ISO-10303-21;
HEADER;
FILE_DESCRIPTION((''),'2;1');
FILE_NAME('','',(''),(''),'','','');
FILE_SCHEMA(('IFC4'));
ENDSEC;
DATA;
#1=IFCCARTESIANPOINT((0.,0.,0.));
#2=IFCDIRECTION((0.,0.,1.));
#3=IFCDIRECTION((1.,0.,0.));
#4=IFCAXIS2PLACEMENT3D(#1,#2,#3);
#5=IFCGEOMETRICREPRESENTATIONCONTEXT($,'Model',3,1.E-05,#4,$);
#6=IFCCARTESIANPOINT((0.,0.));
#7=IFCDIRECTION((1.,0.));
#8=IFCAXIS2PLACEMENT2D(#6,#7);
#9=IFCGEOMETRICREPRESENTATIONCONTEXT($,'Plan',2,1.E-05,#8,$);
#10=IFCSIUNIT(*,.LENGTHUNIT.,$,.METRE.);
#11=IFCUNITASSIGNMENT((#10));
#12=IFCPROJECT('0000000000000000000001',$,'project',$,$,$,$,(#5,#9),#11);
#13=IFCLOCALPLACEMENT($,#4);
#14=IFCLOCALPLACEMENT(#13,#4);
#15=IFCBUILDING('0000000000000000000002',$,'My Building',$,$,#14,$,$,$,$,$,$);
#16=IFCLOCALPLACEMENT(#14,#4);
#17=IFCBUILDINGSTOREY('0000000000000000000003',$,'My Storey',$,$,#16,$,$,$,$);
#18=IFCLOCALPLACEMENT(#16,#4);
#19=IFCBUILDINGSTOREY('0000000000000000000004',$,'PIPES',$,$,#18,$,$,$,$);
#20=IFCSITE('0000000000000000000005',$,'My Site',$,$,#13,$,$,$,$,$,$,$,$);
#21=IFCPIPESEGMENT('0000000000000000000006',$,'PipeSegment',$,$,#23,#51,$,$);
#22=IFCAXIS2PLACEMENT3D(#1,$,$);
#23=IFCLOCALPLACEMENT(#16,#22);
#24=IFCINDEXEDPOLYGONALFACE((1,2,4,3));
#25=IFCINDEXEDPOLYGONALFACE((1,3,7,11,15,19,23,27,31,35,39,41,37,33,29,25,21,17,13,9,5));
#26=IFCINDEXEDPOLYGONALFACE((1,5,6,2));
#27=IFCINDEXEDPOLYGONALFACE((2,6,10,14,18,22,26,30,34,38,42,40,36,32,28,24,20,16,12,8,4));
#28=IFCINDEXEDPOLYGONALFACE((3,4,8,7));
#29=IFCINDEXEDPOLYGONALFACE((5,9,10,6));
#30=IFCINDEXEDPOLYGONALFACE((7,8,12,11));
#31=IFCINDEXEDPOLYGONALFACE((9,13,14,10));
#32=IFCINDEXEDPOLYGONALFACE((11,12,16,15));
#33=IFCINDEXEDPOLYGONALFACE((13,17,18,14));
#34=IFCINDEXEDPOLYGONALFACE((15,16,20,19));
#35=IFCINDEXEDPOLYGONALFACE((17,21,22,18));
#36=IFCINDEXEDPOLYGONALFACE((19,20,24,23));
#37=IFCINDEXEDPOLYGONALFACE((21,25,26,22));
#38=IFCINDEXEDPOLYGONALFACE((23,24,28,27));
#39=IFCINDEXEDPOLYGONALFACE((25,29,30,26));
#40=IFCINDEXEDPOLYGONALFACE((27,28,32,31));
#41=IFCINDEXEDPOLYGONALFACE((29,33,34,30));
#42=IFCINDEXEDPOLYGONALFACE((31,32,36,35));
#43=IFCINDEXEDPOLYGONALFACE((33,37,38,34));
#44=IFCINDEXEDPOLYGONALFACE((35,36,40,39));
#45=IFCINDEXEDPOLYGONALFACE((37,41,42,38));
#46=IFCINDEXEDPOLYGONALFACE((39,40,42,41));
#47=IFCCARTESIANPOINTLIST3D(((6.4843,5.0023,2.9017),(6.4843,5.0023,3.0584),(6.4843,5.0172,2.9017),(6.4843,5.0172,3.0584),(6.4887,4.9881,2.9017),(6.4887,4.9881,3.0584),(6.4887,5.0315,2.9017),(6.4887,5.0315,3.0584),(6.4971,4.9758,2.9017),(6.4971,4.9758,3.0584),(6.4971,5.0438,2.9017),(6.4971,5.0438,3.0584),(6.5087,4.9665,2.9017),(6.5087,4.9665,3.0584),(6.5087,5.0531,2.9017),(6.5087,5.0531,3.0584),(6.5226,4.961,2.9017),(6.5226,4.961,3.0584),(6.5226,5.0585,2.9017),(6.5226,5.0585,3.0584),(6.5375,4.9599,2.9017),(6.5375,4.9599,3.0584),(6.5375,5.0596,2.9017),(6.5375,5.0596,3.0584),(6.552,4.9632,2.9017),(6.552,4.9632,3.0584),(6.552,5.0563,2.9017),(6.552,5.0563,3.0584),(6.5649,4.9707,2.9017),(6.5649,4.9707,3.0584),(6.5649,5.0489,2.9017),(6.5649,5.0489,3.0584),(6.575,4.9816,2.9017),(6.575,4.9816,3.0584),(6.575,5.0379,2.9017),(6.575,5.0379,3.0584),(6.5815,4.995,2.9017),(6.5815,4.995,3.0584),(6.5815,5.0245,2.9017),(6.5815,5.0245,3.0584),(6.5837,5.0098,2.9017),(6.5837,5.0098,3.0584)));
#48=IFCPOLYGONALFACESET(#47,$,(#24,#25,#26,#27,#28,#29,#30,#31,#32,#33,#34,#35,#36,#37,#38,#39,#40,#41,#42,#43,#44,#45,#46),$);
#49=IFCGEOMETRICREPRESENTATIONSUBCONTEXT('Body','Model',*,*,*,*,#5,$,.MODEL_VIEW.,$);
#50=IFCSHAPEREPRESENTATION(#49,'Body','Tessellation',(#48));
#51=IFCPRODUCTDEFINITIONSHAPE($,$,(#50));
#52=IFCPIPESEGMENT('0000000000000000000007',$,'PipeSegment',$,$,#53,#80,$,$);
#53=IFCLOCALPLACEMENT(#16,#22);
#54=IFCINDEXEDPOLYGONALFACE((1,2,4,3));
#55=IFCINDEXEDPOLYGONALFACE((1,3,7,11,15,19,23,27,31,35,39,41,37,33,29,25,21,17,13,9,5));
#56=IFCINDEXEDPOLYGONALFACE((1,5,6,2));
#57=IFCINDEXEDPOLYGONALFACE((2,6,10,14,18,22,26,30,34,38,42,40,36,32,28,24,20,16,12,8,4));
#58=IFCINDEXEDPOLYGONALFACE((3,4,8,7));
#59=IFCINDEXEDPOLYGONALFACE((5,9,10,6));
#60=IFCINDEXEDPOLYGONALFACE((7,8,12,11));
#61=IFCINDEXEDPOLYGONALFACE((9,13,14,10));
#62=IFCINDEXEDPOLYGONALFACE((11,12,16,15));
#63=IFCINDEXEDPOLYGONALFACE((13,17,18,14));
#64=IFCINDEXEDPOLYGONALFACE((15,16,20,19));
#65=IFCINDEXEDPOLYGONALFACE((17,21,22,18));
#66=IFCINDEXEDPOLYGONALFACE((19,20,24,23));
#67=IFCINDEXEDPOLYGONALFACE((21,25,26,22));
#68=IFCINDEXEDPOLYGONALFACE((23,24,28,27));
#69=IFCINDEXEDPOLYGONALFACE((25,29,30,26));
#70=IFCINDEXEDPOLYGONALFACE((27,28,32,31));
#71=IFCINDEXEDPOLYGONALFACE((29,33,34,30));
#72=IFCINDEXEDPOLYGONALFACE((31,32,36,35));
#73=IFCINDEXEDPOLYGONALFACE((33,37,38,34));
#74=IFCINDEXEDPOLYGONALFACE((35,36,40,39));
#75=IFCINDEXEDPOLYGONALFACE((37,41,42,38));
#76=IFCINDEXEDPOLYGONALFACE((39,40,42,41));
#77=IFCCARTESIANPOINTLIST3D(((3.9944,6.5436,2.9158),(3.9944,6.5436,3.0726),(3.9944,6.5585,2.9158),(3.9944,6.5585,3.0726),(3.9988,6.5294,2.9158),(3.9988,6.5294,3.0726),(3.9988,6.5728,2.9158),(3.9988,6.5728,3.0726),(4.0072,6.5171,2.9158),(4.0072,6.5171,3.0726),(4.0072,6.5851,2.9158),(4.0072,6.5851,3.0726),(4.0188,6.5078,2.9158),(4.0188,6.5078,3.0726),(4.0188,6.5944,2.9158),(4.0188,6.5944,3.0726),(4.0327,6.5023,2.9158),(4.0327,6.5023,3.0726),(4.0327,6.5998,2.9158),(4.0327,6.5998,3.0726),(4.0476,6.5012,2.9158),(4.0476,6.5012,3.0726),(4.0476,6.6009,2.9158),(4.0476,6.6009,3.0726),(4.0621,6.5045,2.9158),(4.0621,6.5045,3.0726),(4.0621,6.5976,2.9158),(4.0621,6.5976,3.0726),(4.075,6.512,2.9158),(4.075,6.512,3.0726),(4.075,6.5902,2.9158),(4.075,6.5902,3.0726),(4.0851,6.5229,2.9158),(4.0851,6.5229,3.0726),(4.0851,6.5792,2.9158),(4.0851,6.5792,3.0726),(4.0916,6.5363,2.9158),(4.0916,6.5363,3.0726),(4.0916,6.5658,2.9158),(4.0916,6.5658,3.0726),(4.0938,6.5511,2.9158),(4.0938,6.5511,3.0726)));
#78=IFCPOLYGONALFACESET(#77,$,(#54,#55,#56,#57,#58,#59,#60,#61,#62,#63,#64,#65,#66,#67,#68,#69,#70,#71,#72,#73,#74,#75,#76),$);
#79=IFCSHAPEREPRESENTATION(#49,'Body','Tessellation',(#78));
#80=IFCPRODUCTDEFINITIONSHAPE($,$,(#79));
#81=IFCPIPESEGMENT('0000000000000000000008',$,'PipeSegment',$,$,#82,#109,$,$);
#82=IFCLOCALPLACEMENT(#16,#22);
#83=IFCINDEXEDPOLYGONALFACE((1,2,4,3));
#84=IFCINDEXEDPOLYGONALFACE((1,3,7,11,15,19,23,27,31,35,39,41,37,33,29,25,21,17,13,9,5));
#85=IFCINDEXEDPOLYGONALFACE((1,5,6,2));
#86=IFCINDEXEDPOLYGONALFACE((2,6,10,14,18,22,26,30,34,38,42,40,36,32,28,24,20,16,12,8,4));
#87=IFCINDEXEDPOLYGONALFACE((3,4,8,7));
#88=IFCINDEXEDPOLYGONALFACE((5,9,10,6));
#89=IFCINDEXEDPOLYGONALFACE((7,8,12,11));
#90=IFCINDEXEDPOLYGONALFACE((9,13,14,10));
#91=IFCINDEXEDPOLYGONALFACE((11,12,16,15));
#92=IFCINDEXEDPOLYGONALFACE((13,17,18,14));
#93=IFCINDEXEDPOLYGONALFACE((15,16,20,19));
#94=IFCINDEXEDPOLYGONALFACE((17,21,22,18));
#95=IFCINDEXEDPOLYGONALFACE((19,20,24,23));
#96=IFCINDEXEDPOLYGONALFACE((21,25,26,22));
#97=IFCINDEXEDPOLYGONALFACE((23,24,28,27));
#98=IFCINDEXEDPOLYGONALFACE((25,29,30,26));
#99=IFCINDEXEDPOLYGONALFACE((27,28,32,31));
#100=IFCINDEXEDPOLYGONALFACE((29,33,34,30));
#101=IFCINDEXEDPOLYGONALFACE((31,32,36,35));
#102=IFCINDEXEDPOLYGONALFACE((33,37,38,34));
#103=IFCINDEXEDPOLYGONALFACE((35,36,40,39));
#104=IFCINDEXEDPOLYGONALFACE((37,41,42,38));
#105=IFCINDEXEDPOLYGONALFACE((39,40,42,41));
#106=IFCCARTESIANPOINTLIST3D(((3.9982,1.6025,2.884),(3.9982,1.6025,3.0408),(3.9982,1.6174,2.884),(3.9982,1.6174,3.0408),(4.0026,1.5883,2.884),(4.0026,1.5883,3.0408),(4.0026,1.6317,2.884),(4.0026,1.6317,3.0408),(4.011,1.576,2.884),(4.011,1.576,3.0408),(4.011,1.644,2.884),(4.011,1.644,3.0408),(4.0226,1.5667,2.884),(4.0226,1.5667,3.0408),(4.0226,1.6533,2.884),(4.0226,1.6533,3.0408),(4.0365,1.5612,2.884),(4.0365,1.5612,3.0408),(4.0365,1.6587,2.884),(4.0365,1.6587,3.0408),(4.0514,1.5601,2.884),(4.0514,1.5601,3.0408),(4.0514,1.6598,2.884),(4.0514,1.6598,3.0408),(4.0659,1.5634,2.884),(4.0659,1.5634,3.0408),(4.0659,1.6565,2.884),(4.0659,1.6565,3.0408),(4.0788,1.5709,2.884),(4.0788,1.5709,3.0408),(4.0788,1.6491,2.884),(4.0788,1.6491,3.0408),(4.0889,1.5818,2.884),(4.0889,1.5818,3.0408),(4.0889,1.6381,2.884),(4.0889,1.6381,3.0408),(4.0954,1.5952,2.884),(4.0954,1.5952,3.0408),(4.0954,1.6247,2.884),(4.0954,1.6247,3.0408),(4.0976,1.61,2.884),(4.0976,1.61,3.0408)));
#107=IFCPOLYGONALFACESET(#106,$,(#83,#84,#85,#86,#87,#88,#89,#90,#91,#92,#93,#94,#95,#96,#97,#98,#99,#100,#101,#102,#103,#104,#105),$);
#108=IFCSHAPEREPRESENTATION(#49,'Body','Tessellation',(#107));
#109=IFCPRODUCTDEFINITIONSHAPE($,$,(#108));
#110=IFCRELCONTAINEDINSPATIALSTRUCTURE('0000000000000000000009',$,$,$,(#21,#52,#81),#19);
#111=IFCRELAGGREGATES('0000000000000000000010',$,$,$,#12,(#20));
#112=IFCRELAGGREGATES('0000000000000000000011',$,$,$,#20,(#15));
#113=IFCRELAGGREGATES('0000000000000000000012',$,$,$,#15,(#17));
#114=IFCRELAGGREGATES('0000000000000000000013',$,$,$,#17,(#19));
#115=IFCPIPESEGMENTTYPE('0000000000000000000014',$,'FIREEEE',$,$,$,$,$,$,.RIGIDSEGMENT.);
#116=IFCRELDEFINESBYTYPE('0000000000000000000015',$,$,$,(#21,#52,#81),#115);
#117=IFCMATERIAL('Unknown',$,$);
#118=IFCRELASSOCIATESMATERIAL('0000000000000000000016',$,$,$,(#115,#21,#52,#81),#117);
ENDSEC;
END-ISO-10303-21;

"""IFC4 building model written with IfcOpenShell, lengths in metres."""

from ifc_helpers import new_model, si_unit, frame, origin_with_axes, origin_2d_with_axis, place, context, subcontext, project, spatial, circle, extrude, material, material_profile, profile_set, profile_usage, type_object, element, save


model = new_model("IFC4")

# Units and contexts
model_context = context("Model", 3, precision=1e-05, world=origin_with_axes())
plan_context = context("Plan", 2, precision=1e-05, world=origin_2d_with_axis())
body_context = subcontext(model_context, "Body", "Model", "MODEL_VIEW")
ifc_project = project(units=[si_unit("LENGTHUNIT", "METRE")], contexts=[model_context, plan_context])

# Site, building, storeys
site_placement = place(None, origin_with_axes())
site = spatial("IfcSite", under=ifc_project, at=site_placement, Name="My Site")
building_placement = place(site_placement, origin_with_axes())
building = spatial("IfcBuilding", under=site, at=building_placement, Name="My Building")
storey_1_placement = place(building_placement, origin_with_axes())
storey_1 = spatial("IfcBuildingStorey", under=building, at=storey_1_placement, Name="My Storey")
storey_2_placement = place(storey_1_placement, origin_with_axes())
storey_2 = spatial("IfcBuildingStorey", under=storey_1, at=storey_2_placement, Name="PIPES")

# Pipe segments
ifc_material = material(Name="Unknown")
ifc_material_profile = material_profile(ifc_material, circle(Radius=0.05))
ifc_profile_set = profile_set([ifc_material_profile])
pipe_segment_type = type_object("IfcPipeSegmentType", Name="FIREEEE", PredefinedType="RIGIDSEGMENT", material=ifc_profile_set)
ifc_profile_usage_1 = profile_usage(ifc_profile_set, cardinal=5)
pipe_segment_1_placement = place(storey_2_placement, frame((6.5337, 5.0098, 3.0584), z_axis=(0.0, 0.0, -1.0), x_axis=(1.0, 0.0, 0.0)))
element("IfcPipeSegment", 1, at=pipe_segment_1_placement, inside=storey_2, type_object=pipe_segment_type, material=ifc_profile_usage_1, Name="PipeSegment", context=body_context, shape_type="SweptSolid", body=[
    extrude(circle(Radius=0.05), origin_with_axes(), (0.0, 0.0, 1.0), 0.1567),
])
ifc_profile_usage_2 = profile_usage(ifc_profile_set, cardinal=5)
pipe_segment_2_placement = place(storey_2_placement, frame((4.0438, 6.5511, 3.0726), z_axis=(0.0, 0.0, -1.0), x_axis=(1.0, 0.0, 0.0)))
element("IfcPipeSegment", 2, at=pipe_segment_2_placement, inside=storey_2, type_object=pipe_segment_type, material=ifc_profile_usage_2, Name="PipeSegment", context=body_context, shape_type="SweptSolid", body=[
    extrude(circle(Radius=0.05), origin_with_axes(), (0.0, 0.0, 1.0), 0.1567),
])
ifc_profile_usage_3 = profile_usage(ifc_profile_set, cardinal=5)
pipe_segment_3_placement = place(storey_2_placement, frame((4.0476, 1.61, 3.0408), z_axis=(0.0, 0.0, -1.0), x_axis=(1.0, 0.0, 0.0)))
element("IfcPipeSegment", 3, at=pipe_segment_3_placement, inside=storey_2, type_object=pipe_segment_type, material=ifc_profile_usage_3, Name="PipeSegment", context=body_context, shape_type="SweptSolid", body=[
    extrude(circle(Radius=0.05), origin_with_axes(), (0.0, 0.0, 1.0), 0.1567),
])

save(model, "model.ifc")
